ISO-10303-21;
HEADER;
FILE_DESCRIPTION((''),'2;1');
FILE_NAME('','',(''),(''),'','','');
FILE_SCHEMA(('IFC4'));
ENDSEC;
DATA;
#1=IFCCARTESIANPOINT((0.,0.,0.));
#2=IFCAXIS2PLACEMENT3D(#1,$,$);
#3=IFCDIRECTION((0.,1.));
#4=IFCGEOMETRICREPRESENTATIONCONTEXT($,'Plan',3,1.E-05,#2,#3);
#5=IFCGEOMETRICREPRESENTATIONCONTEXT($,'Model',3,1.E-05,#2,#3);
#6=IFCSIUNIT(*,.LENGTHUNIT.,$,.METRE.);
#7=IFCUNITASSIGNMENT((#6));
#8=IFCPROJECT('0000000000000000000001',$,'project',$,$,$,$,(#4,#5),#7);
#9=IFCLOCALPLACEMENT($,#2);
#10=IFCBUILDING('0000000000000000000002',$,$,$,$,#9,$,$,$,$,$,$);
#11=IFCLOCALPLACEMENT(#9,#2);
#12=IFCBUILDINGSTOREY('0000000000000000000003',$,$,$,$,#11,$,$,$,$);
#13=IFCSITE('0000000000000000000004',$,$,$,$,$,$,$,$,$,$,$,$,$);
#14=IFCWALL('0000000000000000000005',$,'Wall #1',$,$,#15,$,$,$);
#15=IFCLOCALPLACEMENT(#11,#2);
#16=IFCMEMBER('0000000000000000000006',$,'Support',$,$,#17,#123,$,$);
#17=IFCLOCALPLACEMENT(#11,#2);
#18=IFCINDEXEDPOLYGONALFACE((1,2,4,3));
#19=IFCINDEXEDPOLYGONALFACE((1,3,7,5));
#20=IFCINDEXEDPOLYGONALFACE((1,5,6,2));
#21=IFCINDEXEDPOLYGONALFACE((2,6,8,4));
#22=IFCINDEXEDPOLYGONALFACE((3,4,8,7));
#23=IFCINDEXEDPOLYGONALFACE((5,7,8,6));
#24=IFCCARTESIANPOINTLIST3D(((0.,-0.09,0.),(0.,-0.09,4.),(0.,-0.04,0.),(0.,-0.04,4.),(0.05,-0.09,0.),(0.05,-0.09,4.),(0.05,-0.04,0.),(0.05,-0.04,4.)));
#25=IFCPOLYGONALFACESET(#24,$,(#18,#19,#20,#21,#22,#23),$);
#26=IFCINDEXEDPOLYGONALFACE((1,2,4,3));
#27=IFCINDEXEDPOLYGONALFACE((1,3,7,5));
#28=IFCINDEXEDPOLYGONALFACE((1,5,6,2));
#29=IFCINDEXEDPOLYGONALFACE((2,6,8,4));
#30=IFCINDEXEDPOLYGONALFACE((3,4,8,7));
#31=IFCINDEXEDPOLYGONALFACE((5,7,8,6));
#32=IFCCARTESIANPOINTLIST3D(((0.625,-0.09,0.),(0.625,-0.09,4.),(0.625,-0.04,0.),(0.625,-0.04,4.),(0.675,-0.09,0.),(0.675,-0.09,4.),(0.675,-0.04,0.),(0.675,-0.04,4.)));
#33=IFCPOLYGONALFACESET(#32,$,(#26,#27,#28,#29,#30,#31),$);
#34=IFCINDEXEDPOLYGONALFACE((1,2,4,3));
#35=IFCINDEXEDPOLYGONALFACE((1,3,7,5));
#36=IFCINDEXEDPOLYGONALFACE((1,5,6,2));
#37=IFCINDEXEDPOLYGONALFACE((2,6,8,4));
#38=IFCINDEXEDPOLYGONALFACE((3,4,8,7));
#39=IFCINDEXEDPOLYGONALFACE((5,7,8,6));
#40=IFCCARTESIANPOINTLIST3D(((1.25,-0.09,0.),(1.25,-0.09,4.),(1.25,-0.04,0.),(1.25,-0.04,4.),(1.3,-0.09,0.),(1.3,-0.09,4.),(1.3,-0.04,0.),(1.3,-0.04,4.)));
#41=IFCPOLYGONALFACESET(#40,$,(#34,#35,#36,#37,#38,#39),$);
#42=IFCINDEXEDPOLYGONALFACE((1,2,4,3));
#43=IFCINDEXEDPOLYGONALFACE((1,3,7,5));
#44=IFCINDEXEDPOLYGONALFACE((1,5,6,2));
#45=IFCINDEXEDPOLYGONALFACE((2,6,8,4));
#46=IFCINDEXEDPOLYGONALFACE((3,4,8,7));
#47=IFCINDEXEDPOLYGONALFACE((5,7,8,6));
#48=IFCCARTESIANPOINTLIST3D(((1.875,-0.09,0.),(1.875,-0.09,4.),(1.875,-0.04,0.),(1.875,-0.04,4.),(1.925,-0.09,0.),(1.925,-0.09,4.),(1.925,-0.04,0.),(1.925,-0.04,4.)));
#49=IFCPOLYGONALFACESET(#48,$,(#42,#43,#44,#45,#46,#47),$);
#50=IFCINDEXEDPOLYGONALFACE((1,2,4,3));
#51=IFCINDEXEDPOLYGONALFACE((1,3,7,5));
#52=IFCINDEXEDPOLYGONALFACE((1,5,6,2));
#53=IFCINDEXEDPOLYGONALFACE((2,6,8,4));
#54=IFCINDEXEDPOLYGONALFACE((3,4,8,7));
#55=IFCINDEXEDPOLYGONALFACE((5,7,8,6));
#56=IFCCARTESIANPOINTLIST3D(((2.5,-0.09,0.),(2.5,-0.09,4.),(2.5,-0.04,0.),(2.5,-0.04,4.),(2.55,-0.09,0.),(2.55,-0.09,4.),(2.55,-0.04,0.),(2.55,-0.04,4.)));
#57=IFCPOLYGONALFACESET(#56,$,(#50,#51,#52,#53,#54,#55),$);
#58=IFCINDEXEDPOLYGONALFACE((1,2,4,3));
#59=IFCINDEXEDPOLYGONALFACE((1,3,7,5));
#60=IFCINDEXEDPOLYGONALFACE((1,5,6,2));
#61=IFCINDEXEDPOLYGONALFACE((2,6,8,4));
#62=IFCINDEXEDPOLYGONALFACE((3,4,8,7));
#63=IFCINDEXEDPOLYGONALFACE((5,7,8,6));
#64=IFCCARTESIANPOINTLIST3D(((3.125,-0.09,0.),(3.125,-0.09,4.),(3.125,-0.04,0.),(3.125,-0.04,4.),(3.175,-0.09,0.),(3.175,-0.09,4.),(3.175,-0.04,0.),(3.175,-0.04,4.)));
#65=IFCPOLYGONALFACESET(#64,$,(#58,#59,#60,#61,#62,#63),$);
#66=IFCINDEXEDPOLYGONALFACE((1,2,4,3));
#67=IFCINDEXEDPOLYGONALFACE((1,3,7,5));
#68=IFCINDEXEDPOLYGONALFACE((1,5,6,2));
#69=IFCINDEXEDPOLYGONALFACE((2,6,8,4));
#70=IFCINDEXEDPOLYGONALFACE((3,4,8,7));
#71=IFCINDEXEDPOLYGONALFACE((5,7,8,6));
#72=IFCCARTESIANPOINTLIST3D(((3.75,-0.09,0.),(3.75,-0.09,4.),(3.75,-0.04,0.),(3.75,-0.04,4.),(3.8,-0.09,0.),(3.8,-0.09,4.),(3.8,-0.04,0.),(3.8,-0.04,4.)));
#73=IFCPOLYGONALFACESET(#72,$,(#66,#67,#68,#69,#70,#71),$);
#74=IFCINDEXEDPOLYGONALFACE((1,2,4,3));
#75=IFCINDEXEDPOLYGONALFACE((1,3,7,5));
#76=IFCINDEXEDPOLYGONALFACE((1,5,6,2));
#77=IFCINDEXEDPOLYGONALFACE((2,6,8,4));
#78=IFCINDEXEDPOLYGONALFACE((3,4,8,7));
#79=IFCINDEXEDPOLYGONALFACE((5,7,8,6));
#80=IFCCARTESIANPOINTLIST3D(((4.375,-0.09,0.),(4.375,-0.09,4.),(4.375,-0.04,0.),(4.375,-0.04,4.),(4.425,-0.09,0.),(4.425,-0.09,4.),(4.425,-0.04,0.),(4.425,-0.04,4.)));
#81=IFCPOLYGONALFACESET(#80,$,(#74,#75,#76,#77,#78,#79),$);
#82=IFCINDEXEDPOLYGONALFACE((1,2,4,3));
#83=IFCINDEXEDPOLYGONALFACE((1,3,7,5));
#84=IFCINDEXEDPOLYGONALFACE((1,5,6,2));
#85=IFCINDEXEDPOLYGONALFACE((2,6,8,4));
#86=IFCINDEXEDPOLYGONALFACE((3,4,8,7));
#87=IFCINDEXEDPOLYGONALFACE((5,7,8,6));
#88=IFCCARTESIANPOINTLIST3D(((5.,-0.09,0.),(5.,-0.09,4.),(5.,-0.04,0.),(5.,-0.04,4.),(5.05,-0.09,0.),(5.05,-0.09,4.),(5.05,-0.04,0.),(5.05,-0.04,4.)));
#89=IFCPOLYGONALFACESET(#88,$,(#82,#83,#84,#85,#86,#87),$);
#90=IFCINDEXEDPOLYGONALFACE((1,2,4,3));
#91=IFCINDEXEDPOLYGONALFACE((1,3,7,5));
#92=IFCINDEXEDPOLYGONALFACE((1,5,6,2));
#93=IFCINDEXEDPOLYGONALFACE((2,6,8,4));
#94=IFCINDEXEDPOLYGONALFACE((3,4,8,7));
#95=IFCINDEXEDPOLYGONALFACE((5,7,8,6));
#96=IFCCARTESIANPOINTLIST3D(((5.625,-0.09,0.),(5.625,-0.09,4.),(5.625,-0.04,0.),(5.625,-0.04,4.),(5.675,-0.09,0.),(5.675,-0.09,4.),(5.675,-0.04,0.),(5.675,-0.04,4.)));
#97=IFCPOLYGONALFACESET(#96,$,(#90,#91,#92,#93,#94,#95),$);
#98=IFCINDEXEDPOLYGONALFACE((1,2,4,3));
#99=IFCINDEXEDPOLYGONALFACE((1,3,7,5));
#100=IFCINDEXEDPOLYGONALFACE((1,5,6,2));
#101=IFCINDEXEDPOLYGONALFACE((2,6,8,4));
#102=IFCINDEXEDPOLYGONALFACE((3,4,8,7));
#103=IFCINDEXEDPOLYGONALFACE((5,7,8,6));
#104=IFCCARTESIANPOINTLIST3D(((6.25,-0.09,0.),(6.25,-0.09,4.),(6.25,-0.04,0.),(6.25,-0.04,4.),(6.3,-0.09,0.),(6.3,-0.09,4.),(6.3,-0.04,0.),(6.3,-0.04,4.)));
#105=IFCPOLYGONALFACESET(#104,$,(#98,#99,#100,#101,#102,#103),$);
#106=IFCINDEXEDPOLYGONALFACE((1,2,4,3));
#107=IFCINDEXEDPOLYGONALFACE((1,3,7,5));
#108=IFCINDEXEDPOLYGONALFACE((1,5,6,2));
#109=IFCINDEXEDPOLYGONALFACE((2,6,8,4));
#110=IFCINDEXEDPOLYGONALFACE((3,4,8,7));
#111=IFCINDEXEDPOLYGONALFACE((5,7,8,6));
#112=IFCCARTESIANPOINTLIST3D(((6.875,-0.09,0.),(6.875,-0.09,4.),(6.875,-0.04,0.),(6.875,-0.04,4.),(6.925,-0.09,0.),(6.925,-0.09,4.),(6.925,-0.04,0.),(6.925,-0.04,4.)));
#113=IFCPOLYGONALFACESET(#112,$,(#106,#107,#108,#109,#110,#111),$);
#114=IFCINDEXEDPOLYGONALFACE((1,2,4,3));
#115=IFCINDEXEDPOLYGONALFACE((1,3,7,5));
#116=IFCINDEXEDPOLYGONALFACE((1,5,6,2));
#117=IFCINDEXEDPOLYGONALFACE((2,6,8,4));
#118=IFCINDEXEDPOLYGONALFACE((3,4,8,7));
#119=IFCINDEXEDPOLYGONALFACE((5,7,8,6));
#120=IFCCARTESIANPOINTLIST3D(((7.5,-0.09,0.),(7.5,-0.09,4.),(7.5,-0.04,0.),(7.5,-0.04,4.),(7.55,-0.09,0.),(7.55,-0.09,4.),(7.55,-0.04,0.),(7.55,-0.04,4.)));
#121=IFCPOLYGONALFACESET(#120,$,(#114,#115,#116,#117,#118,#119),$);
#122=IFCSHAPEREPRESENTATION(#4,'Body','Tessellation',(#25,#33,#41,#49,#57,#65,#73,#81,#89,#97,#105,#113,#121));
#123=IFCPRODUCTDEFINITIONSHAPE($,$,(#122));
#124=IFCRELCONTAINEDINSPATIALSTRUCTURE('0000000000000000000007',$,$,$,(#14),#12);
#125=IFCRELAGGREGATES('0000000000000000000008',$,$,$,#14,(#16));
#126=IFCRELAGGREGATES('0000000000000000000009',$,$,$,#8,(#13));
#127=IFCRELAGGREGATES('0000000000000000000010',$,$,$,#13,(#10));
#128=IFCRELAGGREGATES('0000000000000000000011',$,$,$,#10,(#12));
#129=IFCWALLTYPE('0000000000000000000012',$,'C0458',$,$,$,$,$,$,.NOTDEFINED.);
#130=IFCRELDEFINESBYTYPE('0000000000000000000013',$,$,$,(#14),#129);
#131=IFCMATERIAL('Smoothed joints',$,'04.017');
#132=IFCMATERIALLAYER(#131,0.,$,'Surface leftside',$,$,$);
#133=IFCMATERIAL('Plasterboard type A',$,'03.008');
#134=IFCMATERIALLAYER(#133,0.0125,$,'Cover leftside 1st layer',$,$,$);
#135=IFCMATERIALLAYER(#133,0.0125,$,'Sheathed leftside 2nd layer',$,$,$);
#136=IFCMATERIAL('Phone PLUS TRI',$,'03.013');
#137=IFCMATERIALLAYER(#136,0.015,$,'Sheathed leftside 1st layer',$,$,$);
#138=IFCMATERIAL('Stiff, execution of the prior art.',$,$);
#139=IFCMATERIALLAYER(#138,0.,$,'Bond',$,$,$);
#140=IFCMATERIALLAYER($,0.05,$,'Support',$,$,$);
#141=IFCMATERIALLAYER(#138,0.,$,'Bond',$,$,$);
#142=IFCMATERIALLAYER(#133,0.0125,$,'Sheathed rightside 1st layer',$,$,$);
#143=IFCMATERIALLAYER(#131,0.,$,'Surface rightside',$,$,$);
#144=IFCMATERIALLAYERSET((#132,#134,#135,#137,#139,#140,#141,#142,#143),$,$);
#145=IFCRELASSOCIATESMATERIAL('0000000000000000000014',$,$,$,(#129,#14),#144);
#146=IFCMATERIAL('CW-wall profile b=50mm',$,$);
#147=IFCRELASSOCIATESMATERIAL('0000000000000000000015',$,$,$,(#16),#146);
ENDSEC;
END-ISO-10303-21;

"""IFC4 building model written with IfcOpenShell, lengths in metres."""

from ifc_helpers import new_model, si_unit, direction, frame, frame_2d, origin, place, context, project, spatial, rectangle, extrude, material, layer, layer_set, type_object, element, aggregate, save


model = new_model("IFC4")

# Units and contexts
plan_context = context("Plan", 3, precision=1e-05, world=origin(), true_north=direction((0.0, 1.0)))
model_context = context("Model", 3, precision=1e-05, world=origin(), true_north=direction((0.0, 1.0)))
ifc_project = project(units=[si_unit("LENGTHUNIT", "METRE")], contexts=[plan_context, model_context])

# Site, building, storey
site = spatial("IfcSite", under=ifc_project)
building_placement = place(None, origin())
building = spatial("IfcBuilding", under=site, at=building_placement)
storey_placement = place(building_placement, origin())
storey = spatial("IfcBuildingStorey", under=building, at=storey_placement)

# Wall, member
ifc_material_1 = material(Name="Smoothed joints", Category="04.017")
ifc_layer_1 = layer(ifc_material_1, 0.0, Name="Surface leftside")
ifc_material_2 = material(Name="Plasterboard type A", Category="03.008")
ifc_layer_2 = layer(ifc_material_2, 0.0125, Name="Cover leftside 1st layer")
ifc_layer_3 = layer(ifc_material_2, 0.0125, Name="Sheathed leftside 2nd layer")
ifc_material_3 = material(Name="Phone PLUS TRI", Category="03.013")
ifc_layer_4 = layer(ifc_material_3, 0.015, Name="Sheathed leftside 1st layer")
ifc_material_4 = material(Name="Stiff, execution of the prior art.")
ifc_layer_5 = layer(ifc_material_4, 0.0, Name="Bond")
ifc_layer_6 = layer(None, 0.05, Name="Support")
ifc_layer_7 = layer(ifc_material_4, 0.0, Name="Bond")
ifc_layer_8 = layer(ifc_material_2, 0.0125, Name="Sheathed rightside 1st layer")
ifc_layer_9 = layer(ifc_material_1, 0.0, Name="Surface rightside")
ifc_layer_set = layer_set([ifc_layer_1, ifc_layer_2, ifc_layer_3, ifc_layer_4, ifc_layer_5, ifc_layer_6, ifc_layer_7, ifc_layer_8, ifc_layer_9])
wall_type = type_object("IfcWallType", Name="C0458", PredefinedType="NOTDEFINED", material=ifc_layer_set)
wall_placement = place(None, frame((0.0, 0.0, 0.0), z_axis=(0.0, -1.0, 0.0), x_axis=(1.0, 0.0, 0.0)))
wall = element("IfcWall", 1, at=wall_placement, inside=storey, type_object=wall_type, material=ifc_layer_set, Name="Wall #1")
ifc_material_5 = material(Name="CW-wall profile b=50mm")
member_1_placement = place(wall_placement, origin())
member_1 = element("IfcMember", 2, at=member_1_placement, material=ifc_material_5, Name="Support", context=plan_context, shape_type="SweptSolid", body=[
    extrude(rectangle(XDim=0.05, YDim=0.05, at=frame_2d((0.025, 0.025), x_axis=(1.0, 0.0))), frame((0.0, 4.0, 0.04), z_axis=(0.0, -1.0, 0.0), x_axis=(1.0, 0.0, 0.0)), (0.0, 0.0, 1.0), 4.0),
    extrude(rectangle(XDim=0.05, YDim=0.05, at=frame_2d((0.025, 0.025), x_axis=(1.0, 0.0))), frame((0.625, 4.0, 0.04), z_axis=(0.0, -1.0, 0.0), x_axis=(1.0, 0.0, 0.0)), (0.0, 0.0, 1.0), 4.0),
    extrude(rectangle(XDim=0.05, YDim=0.05, at=frame_2d((0.025, 0.025), x_axis=(1.0, 0.0))), frame((1.25, 4.0, 0.04), z_axis=(0.0, -1.0, 0.0), x_axis=(1.0, 0.0, 0.0)), (0.0, 0.0, 1.0), 4.0),
    extrude(rectangle(XDim=0.05, YDim=0.05, at=frame_2d((0.025, 0.025), x_axis=(1.0, 0.0))), frame((1.875, 4.0, 0.04), z_axis=(0.0, -1.0, 0.0), x_axis=(1.0, 0.0, 0.0)), (0.0, 0.0, 1.0), 4.0),
    extrude(rectangle(XDim=0.05, YDim=0.05, at=frame_2d((0.025, 0.025), x_axis=(1.0, 0.0))), frame((2.5, 4.0, 0.04), z_axis=(0.0, -1.0, 0.0), x_axis=(1.0, 0.0, 0.0)), (0.0, 0.0, 1.0), 4.0),
    extrude(rectangle(XDim=0.05, YDim=0.05, at=frame_2d((0.025, 0.025), x_axis=(1.0, 0.0))), frame((3.125, 4.0, 0.04), z_axis=(0.0, -1.0, 0.0), x_axis=(1.0, 0.0, 0.0)), (0.0, 0.0, 1.0), 4.0),
    extrude(rectangle(XDim=0.05, YDim=0.05, at=frame_2d((0.025, 0.025), x_axis=(1.0, 0.0))), frame((3.75, 4.0, 0.04), z_axis=(0.0, -1.0, 0.0), x_axis=(1.0, 0.0, 0.0)), (0.0, 0.0, 1.0), 4.0),
    extrude(rectangle(XDim=0.05, YDim=0.05, at=frame_2d((0.025, 0.025), x_axis=(1.0, 0.0))), frame((4.375, 4.0, 0.04), z_axis=(0.0, -1.0, 0.0), x_axis=(1.0, 0.0, 0.0)), (0.0, 0.0, 1.0), 4.0),
    extrude(rectangle(XDim=0.05, YDim=0.05, at=frame_2d((0.025, 0.025), x_axis=(1.0, 0.0))), frame((5.0, 4.0, 0.04), z_axis=(0.0, -1.0, 0.0), x_axis=(1.0, 0.0, 0.0)), (0.0, 0.0, 1.0), 4.0),
    extrude(rectangle(XDim=0.05, YDim=0.05, at=frame_2d((0.025, 0.025), x_axis=(1.0, 0.0))), frame((5.625, 4.0, 0.04), z_axis=(0.0, -1.0, 0.0), x_axis=(1.0, 0.0, 0.0)), (0.0, 0.0, 1.0), 4.0),
    extrude(rectangle(XDim=0.05, YDim=0.05, at=frame_2d((0.025, 0.025), x_axis=(1.0, 0.0))), frame((6.25, 4.0, 0.04), z_axis=(0.0, -1.0, 0.0), x_axis=(1.0, 0.0, 0.0)), (0.0, 0.0, 1.0), 4.0),
    extrude(rectangle(XDim=0.05, YDim=0.05, at=frame_2d((0.025, 0.025), x_axis=(1.0, 0.0))), frame((6.875, 4.0, 0.04), z_axis=(0.0, -1.0, 0.0), x_axis=(1.0, 0.0, 0.0)), (0.0, 0.0, 1.0), 4.0),
    extrude(rectangle(XDim=0.05, YDim=0.05, at=frame_2d((0.025, 0.025), x_axis=(1.0, 0.0))), frame((7.5, 4.0, 0.04), z_axis=(0.0, -1.0, 0.0), x_axis=(1.0, 0.0, 0.0)), (0.0, 0.0, 1.0), 4.0),
])
aggregate(wall, [member_1])

save(model, "model.ifc")
